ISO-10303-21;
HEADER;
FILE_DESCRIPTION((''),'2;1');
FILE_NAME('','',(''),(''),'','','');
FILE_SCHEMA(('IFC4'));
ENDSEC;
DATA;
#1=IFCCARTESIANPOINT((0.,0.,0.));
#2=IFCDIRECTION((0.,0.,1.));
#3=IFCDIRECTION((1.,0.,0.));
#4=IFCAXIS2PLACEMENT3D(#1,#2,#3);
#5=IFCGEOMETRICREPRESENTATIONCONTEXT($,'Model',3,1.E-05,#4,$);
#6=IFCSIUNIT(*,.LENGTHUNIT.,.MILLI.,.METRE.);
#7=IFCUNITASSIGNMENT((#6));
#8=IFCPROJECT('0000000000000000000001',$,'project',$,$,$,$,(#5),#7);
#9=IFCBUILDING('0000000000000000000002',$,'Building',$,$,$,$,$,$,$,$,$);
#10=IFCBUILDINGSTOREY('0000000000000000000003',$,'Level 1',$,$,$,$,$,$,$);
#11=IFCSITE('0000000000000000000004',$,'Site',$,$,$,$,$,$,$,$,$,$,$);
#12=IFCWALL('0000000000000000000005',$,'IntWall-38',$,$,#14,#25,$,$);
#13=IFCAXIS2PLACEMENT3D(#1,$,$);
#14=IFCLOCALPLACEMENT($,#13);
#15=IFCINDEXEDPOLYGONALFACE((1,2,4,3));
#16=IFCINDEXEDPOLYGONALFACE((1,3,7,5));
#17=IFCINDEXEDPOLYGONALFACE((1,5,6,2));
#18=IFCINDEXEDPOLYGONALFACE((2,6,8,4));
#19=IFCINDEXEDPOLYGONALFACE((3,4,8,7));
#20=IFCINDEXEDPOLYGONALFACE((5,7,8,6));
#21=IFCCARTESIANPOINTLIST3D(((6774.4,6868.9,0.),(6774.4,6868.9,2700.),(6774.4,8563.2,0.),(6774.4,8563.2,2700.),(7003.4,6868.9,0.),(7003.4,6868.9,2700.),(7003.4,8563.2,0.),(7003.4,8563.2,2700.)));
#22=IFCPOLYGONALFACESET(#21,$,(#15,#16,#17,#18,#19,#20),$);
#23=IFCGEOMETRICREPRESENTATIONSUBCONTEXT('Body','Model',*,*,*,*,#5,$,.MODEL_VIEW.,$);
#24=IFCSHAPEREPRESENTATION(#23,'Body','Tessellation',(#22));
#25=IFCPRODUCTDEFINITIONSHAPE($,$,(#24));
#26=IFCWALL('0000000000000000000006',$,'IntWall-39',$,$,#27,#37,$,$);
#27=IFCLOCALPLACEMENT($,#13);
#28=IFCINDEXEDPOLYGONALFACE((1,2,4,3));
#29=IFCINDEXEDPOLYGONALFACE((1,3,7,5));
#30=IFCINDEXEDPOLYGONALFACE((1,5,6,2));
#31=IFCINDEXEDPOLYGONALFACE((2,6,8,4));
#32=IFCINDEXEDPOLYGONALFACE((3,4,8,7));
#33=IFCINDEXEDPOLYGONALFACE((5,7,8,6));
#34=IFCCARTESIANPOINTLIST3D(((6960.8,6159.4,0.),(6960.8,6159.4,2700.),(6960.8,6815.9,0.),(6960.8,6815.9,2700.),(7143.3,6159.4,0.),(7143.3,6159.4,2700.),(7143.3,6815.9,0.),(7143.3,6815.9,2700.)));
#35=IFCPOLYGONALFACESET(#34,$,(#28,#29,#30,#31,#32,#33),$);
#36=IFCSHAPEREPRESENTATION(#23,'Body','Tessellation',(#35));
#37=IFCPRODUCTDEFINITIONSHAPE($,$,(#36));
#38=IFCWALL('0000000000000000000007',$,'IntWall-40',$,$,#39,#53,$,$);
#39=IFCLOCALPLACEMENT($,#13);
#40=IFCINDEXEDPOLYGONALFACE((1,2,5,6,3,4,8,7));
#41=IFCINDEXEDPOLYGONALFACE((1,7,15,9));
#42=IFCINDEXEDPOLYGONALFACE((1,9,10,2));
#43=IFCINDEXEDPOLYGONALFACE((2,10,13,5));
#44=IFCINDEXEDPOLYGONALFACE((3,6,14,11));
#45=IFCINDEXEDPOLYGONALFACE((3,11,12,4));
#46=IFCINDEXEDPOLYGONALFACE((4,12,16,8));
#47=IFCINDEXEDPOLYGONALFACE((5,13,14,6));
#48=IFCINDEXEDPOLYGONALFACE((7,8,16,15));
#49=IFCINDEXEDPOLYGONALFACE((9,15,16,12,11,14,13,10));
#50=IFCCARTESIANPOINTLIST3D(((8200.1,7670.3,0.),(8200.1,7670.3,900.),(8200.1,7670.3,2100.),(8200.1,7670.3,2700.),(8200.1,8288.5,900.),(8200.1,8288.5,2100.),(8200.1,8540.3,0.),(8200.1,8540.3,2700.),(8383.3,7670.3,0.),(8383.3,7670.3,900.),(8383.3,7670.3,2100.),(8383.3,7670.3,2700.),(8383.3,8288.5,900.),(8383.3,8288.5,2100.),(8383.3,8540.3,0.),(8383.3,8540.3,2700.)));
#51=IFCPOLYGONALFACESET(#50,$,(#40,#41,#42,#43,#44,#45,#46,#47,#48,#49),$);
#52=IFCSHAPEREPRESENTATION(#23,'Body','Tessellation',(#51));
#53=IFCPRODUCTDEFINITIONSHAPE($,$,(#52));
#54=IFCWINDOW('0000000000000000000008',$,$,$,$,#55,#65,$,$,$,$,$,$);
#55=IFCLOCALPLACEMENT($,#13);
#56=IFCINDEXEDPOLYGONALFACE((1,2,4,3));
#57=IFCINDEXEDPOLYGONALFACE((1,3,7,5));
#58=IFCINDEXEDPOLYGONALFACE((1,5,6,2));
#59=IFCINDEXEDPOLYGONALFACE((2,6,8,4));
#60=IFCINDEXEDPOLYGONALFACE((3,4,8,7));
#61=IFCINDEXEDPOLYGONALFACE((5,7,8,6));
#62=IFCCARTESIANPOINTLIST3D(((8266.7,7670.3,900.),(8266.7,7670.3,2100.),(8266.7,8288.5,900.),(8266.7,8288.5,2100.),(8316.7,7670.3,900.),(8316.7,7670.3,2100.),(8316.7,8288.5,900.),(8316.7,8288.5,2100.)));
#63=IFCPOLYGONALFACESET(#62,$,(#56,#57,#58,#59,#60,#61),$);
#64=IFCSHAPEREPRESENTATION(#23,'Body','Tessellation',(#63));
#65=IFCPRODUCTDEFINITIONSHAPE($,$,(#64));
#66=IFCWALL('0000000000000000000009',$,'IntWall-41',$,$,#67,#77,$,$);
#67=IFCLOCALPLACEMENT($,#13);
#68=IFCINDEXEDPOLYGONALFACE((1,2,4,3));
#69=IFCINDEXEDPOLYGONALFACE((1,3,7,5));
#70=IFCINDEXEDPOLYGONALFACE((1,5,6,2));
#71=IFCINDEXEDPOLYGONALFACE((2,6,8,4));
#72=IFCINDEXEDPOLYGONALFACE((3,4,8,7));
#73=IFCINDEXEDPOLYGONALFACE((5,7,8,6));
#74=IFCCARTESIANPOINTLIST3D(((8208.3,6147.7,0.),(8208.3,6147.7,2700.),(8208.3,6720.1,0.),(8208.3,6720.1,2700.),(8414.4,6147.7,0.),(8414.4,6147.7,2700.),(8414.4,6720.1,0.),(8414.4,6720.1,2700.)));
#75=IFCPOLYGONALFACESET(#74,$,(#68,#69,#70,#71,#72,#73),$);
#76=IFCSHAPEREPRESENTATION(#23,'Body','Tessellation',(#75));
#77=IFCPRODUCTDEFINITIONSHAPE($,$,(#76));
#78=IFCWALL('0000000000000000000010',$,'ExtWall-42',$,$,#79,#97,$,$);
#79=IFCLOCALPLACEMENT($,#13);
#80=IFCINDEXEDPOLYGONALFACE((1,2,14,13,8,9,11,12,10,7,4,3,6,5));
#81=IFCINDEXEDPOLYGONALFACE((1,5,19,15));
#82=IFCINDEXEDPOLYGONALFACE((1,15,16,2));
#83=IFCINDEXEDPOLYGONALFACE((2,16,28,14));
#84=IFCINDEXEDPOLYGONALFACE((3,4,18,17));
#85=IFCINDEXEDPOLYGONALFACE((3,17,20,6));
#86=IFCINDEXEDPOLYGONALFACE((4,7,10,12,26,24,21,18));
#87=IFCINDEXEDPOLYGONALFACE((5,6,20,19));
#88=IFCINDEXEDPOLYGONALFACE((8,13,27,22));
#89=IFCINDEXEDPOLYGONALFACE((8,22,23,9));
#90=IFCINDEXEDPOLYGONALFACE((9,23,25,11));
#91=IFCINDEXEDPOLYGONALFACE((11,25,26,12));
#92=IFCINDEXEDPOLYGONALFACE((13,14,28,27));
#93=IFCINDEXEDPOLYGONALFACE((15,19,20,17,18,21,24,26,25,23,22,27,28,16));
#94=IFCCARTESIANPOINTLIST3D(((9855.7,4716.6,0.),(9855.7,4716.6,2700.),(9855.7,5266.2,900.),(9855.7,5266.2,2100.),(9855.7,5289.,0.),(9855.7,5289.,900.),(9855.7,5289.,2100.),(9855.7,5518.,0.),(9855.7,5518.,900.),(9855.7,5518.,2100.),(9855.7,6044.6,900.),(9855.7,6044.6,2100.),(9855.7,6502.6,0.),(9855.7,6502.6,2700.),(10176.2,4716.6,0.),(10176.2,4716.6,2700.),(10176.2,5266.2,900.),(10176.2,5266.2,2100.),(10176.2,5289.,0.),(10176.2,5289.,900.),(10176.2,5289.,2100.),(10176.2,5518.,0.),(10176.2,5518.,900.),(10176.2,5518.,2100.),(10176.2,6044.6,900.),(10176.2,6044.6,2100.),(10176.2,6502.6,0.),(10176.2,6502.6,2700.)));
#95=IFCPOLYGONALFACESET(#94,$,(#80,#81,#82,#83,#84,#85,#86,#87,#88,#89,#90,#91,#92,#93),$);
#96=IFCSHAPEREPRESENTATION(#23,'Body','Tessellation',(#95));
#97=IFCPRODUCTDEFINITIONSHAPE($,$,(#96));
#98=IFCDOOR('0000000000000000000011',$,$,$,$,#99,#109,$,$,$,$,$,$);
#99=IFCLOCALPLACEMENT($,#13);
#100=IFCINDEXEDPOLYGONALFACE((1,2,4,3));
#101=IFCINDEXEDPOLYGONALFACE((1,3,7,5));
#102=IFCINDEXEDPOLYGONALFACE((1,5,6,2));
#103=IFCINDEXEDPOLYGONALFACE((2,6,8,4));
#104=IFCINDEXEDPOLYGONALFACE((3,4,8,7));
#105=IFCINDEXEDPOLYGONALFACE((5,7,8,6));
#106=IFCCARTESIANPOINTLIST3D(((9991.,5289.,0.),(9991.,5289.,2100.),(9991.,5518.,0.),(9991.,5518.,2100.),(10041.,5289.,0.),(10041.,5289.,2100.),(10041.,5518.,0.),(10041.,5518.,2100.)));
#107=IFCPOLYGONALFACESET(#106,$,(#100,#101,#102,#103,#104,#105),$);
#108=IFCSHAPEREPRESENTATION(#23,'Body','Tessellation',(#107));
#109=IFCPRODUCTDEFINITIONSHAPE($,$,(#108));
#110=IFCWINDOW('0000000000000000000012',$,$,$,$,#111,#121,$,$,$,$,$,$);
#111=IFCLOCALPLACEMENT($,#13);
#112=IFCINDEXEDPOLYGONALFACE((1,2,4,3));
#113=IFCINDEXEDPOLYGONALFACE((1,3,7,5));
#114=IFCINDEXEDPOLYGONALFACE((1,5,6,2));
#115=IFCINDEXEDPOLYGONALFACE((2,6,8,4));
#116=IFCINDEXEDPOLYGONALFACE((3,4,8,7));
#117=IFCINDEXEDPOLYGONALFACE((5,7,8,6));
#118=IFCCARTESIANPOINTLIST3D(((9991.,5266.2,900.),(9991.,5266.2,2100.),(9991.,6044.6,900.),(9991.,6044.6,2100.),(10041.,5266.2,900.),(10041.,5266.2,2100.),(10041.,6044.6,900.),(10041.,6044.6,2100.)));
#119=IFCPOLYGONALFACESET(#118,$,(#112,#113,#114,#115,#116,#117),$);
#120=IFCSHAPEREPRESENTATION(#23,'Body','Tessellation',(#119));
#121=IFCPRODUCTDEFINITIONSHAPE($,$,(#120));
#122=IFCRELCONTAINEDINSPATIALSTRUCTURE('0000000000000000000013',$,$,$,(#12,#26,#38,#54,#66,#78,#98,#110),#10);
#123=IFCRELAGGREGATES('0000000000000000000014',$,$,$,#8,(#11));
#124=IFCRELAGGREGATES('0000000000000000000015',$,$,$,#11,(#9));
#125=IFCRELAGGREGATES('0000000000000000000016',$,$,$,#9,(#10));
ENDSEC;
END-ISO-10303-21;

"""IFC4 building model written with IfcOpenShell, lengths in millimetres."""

from ifc_helpers import new_model, si_unit, frame, origin_with_axes, place, context, subcontext, project, spatial, indexed_curve, outline, extrude, element, fill, save


model = new_model("IFC4")

# Units and contexts
model_context = context("Model", 3, precision=1e-05, world=origin_with_axes())
body_context = subcontext(model_context, "Body", "Model", "MODEL_VIEW")
ifc_project = project(units=[si_unit("LENGTHUNIT", "METRE", prefix="MILLI")], contexts=[model_context])

# Site, building, storey
site = spatial("IfcSite", under=ifc_project, Name="Site")
building = spatial("IfcBuilding", under=site, Name="Building")
storey = spatial("IfcBuildingStorey", under=building, Name="Level 1")

# Walls
wall_1_placement = place(None, frame((6888.9, 6868.9, 0.0), z_axis=(0.0, 0.0, 1.0), x_axis=(0.0, 1.0, 0.0)))
element("IfcWall", 1, at=wall_1_placement, inside=storey, Name="IntWall-38", context=body_context, shape_type="SweptSolid", body=[
    extrude(outline(indexed_curve([(0.0, 0.0), (0.0, 229.0), (1694.3, 229.0), (1694.3, 0.0), (0.0, 0.0)], self_intersect=False)), frame((0.0, -114.5, 0.0), z_axis=(0.0, 0.0, 1.0), x_axis=(1.0, 0.0, 0.0)), (0.0, 0.0, 1.0), 2700.0),
])
wall_2_placement = place(None, frame((7052.1, 6159.4, 0.0), z_axis=(0.0, 0.0, 1.0), x_axis=(0.0, 1.0, 0.0)))
element("IfcWall", 2, at=wall_2_placement, inside=storey, Name="IntWall-39", context=body_context, shape_type="SweptSolid", body=[
    extrude(outline(indexed_curve([(0.0, 0.0), (0.0, 182.5), (656.5, 182.5), (656.5, 0.0), (0.0, 0.0)], self_intersect=False)), frame((0.0, -91.3, 0.0), z_axis=(0.0, 0.0, 1.0), x_axis=(1.0, 0.0, 0.0)), (0.0, 0.0, 1.0), 2700.0),
])

# Wall, opening, window
wall_3_placement = place(None, frame((8291.7, 7670.3, 0.0), z_axis=(0.0, 0.0, 1.0), x_axis=(0.0, 1.0, 0.0)))
wall_3 = element("IfcWall", 3, at=wall_3_placement, inside=storey, Name="IntWall-40", context=body_context, shape_type="SweptSolid", body=[
    extrude(outline(indexed_curve([(0.0, 0.0), (0.0, 183.2), (870.1, 183.2), (870.1, 0.0), (0.0, 0.0)], self_intersect=False)), frame((0.0, -91.6, 0.0), z_axis=(0.0, 0.0, 1.0), x_axis=(1.0, 0.0, 0.0)), (0.0, 0.0, 1.0), 2700.0),
])
opening_1_placement = place(wall_3_placement, frame((0.0, 0.0, 900.0), z_axis=(0.0, 0.0, 1.0), x_axis=(1.0, 0.0, 0.0)))
opening_1 = element("IfcOpeningElement", 4, at=opening_1_placement, cuts=wall_3, context=body_context, shape_type="SweptSolid", body=[
    extrude(outline(indexed_curve([(0.0, 0.0), (0.0, 283.2), (618.2, 283.2), (618.2, 0.0), (0.0, 0.0)], self_intersect=False)), frame((0.0, -141.6, 0.0), z_axis=(0.0, 0.0, 1.0), x_axis=(1.0, 0.0, 0.0)), (0.0, 0.0, 1.0), 1200.0),
])
window_1_placement = place(opening_1_placement, origin_with_axes())
window_1 = element("IfcWindow", 5, at=window_1_placement, inside=storey, context=body_context, shape_type="SweptSolid", body=[
    extrude(outline(indexed_curve([(0.0, 0.0), (0.0, 50.0), (618.2, 50.0), (618.2, 0.0), (0.0, 0.0)], self_intersect=False)), frame((0.0, -25.0, 0.0), z_axis=(0.0, 0.0, 1.0), x_axis=(1.0, 0.0, 0.0)), (0.0, 0.0, 1.0), 1200.0),
])
fill(opening_1, window_1)

# Wall
wall_4_placement = place(None, frame((8311.4, 6147.7, 0.0), z_axis=(0.0, 0.0, 1.0), x_axis=(0.0, 1.0, 0.0)))
element("IfcWall", 6, at=wall_4_placement, inside=storey, Name="IntWall-41", context=body_context, shape_type="SweptSolid", body=[
    extrude(outline(indexed_curve([(0.0, 0.0), (0.0, 206.1), (572.4, 206.1), (572.4, 0.0), (0.0, 0.0)], self_intersect=False)), frame((0.0, -103.0, 0.0), z_axis=(0.0, 0.0, 1.0), x_axis=(1.0, 0.0, 0.0)), (0.0, 0.0, 1.0), 2700.0),
])

# Wall, openings, door, window
wall_5_placement = place(None, frame((10016.0, 4716.6, 0.0), z_axis=(0.0, 0.0, 1.0), x_axis=(0.0, 1.0, 0.0)))
wall_5 = element("IfcWall", 7, at=wall_5_placement, inside=storey, Name="ExtWall-42", context=body_context, shape_type="SweptSolid", body=[
    extrude(outline(indexed_curve([(0.0, 0.0), (0.0, 320.5), (1785.9, 320.5), (1785.9, 0.0), (0.0, 0.0)], self_intersect=False)), frame((0.0, -160.3, 0.0), z_axis=(0.0, 0.0, 1.0), x_axis=(1.0, 0.0, 0.0)), (0.0, 0.0, 1.0), 2700.0),
])
opening_2_placement = place(wall_5_placement, frame((572.4, 0.0, 0.0), z_axis=(0.0, 0.0, 1.0), x_axis=(1.0, 0.0, 0.0)))
opening_2 = element("IfcOpeningElement", 8, at=opening_2_placement, cuts=wall_5, context=body_context, shape_type="SweptSolid", body=[
    extrude(outline(indexed_curve([(0.0, 0.0), (0.0, 420.5), (229.0, 420.5), (229.0, 0.0), (0.0, 0.0)], self_intersect=False)), frame((0.0, -210.3, 0.0), z_axis=(0.0, 0.0, 1.0), x_axis=(1.0, 0.0, 0.0)), (0.0, 0.0, 1.0), 2100.0),
])
opening_3_placement = place(wall_5_placement, frame((549.5, 0.0, 900.0), z_axis=(0.0, 0.0, 1.0), x_axis=(1.0, 0.0, 0.0)))
opening_3 = element("IfcOpeningElement", 9, at=opening_3_placement, cuts=wall_5, context=body_context, shape_type="SweptSolid", body=[
    extrude(outline(indexed_curve([(0.0, 0.0), (0.0, 420.5), (778.5, 420.5), (778.5, 0.0), (0.0, 0.0)], self_intersect=False)), frame((0.0, -210.3, 0.0), z_axis=(0.0, 0.0, 1.0), x_axis=(1.0, 0.0, 0.0)), (0.0, 0.0, 1.0), 1200.0),
])
door_1_placement = place(opening_2_placement, origin_with_axes())
door_1 = element("IfcDoor", 10, at=door_1_placement, inside=storey, context=body_context, shape_type="SweptSolid", body=[
    extrude(outline(indexed_curve([(0.0, 0.0), (0.0, 50.0), (229.0, 50.0), (229.0, 0.0), (0.0, 0.0)], self_intersect=False)), frame((0.0, -25.0, 0.0), z_axis=(0.0, 0.0, 1.0), x_axis=(1.0, 0.0, 0.0)), (0.0, 0.0, 1.0), 2100.0),
])
fill(opening_2, door_1)
window_2_placement = place(opening_3_placement, origin_with_axes())
window_2 = element("IfcWindow", 11, at=window_2_placement, inside=storey, context=body_context, shape_type="SweptSolid", body=[
    extrude(outline(indexed_curve([(0.0, 0.0), (0.0, 50.0), (778.5, 50.0), (778.5, 0.0), (0.0, 0.0)], self_intersect=False)), frame((0.0, -25.0, 0.0), z_axis=(0.0, 0.0, 1.0), x_axis=(1.0, 0.0, 0.0)), (0.0, 0.0, 1.0), 1200.0),
])
fill(opening_3, window_2)

save(model, "model.ifc")
